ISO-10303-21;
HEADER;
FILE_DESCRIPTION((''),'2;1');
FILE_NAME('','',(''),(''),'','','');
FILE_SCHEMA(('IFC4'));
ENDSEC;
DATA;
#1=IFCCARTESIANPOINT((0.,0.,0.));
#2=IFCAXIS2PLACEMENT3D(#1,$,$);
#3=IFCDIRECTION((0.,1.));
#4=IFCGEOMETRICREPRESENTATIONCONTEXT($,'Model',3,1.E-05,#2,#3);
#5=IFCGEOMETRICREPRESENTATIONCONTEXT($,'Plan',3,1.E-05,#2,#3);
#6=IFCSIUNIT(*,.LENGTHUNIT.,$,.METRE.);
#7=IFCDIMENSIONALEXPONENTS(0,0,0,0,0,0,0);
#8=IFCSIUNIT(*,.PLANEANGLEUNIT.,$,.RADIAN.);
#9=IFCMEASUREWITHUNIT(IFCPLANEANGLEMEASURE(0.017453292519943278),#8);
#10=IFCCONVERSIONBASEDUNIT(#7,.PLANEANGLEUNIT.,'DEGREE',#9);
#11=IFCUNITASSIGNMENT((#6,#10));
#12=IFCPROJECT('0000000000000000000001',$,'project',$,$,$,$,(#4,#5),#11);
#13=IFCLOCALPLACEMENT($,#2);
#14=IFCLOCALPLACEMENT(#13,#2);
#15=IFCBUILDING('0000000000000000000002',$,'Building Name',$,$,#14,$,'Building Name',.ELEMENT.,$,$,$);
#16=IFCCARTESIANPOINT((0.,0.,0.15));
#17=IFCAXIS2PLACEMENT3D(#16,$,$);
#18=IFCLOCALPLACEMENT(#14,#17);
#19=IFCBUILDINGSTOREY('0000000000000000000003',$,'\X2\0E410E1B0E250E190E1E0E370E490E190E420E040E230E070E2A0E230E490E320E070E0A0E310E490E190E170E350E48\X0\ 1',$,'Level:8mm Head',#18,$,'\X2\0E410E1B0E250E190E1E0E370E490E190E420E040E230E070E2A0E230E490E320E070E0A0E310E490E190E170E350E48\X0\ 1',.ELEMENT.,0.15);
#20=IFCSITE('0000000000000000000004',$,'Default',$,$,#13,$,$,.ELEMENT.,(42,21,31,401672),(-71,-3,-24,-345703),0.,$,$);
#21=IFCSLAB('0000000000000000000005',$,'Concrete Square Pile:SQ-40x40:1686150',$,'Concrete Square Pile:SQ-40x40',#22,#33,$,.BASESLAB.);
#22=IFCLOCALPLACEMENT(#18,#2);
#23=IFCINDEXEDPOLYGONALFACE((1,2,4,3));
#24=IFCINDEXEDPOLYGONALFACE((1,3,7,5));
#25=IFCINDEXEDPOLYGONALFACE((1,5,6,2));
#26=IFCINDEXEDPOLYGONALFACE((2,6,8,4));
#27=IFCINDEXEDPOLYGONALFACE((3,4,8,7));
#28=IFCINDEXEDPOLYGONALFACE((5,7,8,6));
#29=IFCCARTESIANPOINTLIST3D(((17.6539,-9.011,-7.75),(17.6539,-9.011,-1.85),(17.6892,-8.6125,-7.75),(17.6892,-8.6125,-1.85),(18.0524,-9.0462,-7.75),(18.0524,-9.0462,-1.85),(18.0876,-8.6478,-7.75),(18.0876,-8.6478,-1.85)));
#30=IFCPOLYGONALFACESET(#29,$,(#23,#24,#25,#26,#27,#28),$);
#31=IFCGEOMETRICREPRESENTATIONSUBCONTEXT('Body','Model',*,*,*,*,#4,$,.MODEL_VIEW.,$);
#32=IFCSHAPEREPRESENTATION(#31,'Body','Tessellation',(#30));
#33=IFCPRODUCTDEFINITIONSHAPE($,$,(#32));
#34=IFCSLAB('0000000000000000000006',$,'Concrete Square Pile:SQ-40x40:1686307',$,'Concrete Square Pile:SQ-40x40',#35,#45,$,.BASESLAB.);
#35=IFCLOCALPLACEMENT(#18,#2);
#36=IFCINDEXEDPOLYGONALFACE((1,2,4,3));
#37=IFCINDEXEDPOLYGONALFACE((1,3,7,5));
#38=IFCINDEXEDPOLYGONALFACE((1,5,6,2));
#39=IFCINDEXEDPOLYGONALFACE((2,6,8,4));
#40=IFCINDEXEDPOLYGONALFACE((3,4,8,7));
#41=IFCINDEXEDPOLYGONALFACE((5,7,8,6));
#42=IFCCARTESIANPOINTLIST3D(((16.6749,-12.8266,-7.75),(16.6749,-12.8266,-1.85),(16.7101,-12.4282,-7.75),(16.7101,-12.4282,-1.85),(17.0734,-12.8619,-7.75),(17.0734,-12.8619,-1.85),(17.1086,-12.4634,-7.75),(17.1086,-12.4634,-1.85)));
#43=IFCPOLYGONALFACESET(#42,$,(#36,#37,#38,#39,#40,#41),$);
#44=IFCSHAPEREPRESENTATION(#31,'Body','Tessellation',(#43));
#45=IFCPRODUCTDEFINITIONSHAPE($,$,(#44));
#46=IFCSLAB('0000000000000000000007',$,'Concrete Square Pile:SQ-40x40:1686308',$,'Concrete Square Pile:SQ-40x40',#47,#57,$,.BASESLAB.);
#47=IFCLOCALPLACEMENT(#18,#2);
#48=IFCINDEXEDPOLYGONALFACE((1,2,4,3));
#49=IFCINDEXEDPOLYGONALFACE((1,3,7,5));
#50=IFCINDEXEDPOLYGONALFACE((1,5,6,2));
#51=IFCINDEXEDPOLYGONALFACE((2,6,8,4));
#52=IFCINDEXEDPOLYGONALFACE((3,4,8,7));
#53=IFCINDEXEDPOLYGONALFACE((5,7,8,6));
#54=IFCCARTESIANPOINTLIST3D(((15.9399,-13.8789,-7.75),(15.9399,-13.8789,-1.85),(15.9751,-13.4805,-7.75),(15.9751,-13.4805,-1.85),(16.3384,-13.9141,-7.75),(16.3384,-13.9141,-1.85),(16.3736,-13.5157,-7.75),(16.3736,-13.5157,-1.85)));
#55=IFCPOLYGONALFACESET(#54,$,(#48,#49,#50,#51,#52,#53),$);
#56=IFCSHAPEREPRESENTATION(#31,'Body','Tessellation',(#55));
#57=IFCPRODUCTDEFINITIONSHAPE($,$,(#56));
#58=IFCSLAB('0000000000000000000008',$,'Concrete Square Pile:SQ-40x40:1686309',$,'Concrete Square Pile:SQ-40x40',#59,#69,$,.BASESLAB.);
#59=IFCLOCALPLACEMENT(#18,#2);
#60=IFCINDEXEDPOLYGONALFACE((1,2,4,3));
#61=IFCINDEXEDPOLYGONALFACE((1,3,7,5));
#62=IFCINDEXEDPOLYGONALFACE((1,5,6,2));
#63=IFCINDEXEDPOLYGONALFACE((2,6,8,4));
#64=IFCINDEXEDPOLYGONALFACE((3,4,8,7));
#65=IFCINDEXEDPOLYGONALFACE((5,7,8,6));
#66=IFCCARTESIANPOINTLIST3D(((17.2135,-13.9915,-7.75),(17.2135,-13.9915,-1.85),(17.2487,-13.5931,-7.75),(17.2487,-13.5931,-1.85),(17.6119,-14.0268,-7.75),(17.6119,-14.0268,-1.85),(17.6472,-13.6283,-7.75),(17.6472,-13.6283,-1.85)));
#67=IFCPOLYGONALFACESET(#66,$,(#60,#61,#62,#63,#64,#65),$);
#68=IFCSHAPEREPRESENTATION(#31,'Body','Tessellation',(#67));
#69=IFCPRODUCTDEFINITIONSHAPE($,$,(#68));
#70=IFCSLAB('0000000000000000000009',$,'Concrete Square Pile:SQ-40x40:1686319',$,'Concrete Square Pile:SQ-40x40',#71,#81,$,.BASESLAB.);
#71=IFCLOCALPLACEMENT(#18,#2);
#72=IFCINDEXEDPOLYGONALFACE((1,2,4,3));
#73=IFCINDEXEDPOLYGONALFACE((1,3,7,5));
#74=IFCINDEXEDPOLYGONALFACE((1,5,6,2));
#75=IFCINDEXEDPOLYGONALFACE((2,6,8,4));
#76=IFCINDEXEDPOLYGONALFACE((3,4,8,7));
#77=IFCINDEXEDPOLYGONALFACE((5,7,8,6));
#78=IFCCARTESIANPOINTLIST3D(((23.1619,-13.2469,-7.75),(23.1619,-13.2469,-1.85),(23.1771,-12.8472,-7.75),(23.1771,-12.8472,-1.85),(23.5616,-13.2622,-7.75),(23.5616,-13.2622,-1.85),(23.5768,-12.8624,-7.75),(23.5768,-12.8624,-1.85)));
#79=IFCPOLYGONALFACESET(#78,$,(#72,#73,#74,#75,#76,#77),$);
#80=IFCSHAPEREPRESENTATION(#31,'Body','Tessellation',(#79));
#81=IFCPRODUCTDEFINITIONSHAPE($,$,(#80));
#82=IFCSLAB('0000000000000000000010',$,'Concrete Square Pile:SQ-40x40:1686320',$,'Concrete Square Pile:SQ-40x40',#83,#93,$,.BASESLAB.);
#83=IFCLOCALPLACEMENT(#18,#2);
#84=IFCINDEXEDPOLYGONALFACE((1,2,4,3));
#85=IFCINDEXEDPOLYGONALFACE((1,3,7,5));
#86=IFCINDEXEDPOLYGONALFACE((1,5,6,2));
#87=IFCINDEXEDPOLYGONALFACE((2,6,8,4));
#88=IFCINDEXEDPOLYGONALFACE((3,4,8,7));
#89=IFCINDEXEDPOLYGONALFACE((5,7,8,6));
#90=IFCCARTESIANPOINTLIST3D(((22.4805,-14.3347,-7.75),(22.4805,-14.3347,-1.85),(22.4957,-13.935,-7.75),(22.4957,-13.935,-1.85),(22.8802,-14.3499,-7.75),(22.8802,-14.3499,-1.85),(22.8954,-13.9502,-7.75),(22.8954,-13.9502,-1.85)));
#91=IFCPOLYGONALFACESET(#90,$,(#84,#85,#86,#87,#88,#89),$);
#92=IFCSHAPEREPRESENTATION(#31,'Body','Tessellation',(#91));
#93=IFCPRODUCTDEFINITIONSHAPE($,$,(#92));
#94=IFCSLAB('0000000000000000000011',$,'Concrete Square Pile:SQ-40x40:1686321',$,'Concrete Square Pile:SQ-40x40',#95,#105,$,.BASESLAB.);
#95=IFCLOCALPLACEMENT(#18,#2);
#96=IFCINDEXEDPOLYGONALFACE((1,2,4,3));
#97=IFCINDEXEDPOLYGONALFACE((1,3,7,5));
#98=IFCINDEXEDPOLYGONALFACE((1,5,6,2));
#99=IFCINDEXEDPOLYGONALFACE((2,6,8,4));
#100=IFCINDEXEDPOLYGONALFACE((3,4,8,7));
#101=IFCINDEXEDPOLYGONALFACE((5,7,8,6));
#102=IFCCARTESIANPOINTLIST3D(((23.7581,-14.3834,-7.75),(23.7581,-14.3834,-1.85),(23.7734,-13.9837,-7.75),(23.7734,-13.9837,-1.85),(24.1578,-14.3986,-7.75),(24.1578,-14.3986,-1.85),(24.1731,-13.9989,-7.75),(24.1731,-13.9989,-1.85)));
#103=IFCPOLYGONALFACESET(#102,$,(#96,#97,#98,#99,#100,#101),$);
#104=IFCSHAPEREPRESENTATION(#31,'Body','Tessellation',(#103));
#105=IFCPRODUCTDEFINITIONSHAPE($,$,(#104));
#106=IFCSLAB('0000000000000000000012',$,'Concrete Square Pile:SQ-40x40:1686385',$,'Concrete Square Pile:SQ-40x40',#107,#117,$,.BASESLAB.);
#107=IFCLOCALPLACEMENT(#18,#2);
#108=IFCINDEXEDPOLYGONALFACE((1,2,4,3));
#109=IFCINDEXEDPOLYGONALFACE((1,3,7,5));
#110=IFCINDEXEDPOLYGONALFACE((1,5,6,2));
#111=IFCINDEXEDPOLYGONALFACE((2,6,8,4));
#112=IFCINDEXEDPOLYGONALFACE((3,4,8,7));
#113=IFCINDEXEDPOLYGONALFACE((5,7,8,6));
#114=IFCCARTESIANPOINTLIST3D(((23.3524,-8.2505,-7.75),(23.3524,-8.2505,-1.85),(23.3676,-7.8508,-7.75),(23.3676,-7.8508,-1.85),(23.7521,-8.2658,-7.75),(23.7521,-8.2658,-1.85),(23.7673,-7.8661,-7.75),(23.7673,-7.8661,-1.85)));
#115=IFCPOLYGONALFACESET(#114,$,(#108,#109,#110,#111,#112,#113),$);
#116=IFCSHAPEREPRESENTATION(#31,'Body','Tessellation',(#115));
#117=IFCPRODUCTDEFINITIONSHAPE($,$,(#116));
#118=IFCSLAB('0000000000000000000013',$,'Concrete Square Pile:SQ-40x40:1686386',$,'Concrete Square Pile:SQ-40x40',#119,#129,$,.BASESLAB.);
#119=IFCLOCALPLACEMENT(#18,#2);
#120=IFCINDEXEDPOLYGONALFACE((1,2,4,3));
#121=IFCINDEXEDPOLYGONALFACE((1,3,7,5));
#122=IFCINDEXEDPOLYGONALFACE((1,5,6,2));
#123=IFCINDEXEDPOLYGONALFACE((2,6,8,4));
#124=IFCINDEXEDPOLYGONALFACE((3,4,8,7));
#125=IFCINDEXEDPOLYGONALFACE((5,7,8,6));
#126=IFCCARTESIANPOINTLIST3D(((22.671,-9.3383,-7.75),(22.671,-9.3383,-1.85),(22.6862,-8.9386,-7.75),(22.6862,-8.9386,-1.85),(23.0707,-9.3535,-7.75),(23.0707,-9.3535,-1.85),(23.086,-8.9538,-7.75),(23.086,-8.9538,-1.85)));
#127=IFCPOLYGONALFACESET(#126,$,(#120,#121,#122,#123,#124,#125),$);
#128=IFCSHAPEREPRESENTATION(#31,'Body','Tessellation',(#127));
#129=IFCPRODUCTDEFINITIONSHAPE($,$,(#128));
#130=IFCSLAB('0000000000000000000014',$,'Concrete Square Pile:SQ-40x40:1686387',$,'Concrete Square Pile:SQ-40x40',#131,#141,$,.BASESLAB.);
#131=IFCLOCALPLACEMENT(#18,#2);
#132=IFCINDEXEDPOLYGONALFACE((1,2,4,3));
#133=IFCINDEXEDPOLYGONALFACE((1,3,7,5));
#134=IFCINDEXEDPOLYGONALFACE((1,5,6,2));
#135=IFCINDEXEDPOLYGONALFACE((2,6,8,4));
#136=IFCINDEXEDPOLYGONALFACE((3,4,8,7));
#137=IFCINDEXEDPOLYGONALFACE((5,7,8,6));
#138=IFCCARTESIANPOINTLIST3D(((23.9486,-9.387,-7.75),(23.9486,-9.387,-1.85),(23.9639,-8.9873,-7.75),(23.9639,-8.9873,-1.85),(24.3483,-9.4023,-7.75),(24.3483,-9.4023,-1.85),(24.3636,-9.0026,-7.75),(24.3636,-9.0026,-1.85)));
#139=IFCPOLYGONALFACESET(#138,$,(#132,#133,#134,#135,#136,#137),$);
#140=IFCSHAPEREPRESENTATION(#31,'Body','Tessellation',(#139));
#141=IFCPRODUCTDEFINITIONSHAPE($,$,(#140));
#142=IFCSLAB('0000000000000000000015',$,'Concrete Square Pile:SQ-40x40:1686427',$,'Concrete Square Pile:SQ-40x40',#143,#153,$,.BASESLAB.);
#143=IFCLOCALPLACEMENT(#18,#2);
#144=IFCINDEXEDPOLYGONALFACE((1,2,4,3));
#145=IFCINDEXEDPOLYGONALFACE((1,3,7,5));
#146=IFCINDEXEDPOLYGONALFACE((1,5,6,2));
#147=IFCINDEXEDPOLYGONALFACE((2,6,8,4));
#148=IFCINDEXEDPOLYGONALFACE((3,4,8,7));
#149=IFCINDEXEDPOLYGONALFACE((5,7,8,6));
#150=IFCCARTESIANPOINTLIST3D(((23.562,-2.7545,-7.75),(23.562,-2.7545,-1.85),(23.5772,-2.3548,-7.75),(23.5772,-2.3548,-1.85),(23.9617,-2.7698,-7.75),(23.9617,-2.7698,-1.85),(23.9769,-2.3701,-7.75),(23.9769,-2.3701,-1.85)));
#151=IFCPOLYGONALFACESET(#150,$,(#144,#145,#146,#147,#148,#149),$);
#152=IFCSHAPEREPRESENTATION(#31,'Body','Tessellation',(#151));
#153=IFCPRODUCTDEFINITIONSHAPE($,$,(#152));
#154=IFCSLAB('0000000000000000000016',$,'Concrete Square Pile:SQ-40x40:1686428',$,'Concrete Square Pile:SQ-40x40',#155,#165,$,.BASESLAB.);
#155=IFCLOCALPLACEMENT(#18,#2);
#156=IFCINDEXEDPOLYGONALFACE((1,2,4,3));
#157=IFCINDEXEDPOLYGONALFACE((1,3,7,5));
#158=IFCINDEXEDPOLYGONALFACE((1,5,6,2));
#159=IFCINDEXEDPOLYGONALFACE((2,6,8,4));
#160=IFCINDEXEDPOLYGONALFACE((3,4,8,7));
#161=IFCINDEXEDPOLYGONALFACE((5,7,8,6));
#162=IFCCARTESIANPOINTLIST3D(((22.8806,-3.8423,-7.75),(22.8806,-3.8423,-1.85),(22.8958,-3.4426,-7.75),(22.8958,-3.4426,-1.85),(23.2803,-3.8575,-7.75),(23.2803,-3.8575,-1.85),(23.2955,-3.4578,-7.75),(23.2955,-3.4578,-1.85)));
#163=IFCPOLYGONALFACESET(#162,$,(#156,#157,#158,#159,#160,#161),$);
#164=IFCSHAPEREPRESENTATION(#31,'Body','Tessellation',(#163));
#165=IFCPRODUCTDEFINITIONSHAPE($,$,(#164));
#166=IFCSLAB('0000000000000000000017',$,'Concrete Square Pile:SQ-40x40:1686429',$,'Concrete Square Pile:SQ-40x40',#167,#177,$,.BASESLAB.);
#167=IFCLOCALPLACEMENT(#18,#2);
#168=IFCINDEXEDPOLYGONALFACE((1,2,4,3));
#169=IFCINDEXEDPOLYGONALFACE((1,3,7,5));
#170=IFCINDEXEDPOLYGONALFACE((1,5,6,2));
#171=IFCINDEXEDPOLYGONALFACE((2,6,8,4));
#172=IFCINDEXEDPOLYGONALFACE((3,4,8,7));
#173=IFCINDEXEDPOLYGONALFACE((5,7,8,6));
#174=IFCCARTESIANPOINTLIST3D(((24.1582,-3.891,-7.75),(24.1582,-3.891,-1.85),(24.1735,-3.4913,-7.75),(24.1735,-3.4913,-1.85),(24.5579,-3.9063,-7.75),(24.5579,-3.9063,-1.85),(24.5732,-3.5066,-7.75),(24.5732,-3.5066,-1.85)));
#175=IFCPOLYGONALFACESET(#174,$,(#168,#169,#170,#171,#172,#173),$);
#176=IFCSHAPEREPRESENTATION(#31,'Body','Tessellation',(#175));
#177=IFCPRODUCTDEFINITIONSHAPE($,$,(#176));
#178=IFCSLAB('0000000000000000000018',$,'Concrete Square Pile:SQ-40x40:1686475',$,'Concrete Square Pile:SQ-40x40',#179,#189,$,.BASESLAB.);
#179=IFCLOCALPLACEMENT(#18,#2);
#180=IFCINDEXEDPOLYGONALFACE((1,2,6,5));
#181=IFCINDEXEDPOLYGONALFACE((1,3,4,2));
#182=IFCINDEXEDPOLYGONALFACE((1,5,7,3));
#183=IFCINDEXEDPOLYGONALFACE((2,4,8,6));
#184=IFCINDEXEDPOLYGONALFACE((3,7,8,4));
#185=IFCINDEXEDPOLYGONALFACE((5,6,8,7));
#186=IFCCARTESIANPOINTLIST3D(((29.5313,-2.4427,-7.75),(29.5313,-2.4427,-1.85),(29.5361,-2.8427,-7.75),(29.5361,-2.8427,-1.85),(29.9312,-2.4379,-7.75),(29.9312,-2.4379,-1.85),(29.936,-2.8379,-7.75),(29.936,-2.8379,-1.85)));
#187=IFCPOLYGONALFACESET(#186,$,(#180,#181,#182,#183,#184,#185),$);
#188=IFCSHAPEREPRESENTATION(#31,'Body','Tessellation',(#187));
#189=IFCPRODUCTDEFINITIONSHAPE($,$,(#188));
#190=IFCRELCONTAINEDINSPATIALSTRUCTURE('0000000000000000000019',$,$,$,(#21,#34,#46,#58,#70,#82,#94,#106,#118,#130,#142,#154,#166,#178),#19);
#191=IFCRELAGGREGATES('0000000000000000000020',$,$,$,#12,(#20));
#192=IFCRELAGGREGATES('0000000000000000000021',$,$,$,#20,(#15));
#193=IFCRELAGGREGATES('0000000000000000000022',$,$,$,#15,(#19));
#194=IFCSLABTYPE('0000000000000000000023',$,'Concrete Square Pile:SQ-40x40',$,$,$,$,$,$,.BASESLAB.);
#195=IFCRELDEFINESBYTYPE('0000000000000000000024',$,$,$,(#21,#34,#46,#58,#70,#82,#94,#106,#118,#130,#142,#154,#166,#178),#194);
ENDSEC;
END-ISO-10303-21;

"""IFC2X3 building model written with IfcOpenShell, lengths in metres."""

from ifc_helpers import new_model, entity, si_unit, converted_unit, direction, frame, frame_2d, origin, origin_2d_with_axis, place, context, subcontext, project, spatial, rectangle, extrude, type_object, element, save


model = new_model("IFC2X3")

# Units and contexts
model_context = context("Model", 3, precision=1e-05, world=origin(), true_north=direction((0.0, 1.0)))
plan_context = context("Plan", 3, precision=1e-05, world=origin(), true_north=direction((0.0, 1.0)))
body_context = subcontext(model_context, "Body", "Model", "MODEL_VIEW")
ifc_project = project(units=[si_unit("LENGTHUNIT", "METRE"), converted_unit("PLANEANGLEUNIT", "DEGREE", entity("IfcPlaneAngleMeasure", 0.017453292519943278), si_unit("PLANEANGLEUNIT", "RADIAN"), dimensions=[0, 0, 0, 0, 0, 0, 0])], contexts=[model_context, plan_context])

# Site, building, storey
site_placement = place(None, origin())
site = spatial("IfcSite", under=ifc_project, at=site_placement, Name="Default", CompositionType="ELEMENT", RefLatitude=(42, 21, 31, 401672), RefLongitude=(-71, -3, -24, -345703), RefElevation=0.0)
building_placement = place(site_placement, origin())
building = spatial("IfcBuilding", under=site, at=building_placement, Name="Building Name", LongName="Building Name", CompositionType="ELEMENT")
storey_placement = place(building_placement, frame((0.0, 0.0, 0.15)))
storey = spatial("IfcBuildingStorey", under=building, at=storey_placement, Name="แปลนพื้นโครงสร้างชั้นที่ 1", ObjectType="Level:8mm Head", LongName="แปลนพื้นโครงสร้างชั้นที่ 1", CompositionType="ELEMENT", Elevation=0.15)

# Slabs
slab_type_1 = type_object("IfcSlabType", Name="Concrete Square Pile:SQ-40x40", PredefinedType="BASESLAB")
slab_1_placement = place(storey_placement, origin())
element("IfcSlab", 1, at=slab_1_placement, inside=storey, type_object=slab_type_1, Name="Concrete Square Pile:SQ-40x40:1686150", ObjectType="Concrete Square Pile:SQ-40x40", PredefinedType="BASESLAB", context=body_context, shape_type="SweptSolid", body=[
    extrude(rectangle(XDim=0.4, YDim=0.4, at=origin_2d_with_axis()), frame((17.8708, -8.8294, -7.75), z_axis=(0.0, 0.0, 1.0), x_axis=(-0.996113, 0.088086, 0.0)), (0.0, 0.0, 1.0), 5.9),
])
slab_2_placement = place(storey_placement, origin())
element("IfcSlab", 2, at=slab_2_placement, inside=storey, type_object=slab_type_1, Name="Concrete Square Pile:SQ-40x40:1686307", ObjectType="Concrete Square Pile:SQ-40x40", PredefinedType="BASESLAB", context=body_context, shape_type="SweptSolid", body=[
    extrude(rectangle(XDim=0.4, YDim=0.4, at=origin_2d_with_axis()), frame((16.8917, -12.645, -7.75), z_axis=(0.0, 0.0, 1.0), x_axis=(-0.996113, 0.088086, 0.0)), (0.0, 0.0, 1.0), 5.9),
])
slab_3_placement = place(storey_placement, origin())
element("IfcSlab", 3, at=slab_3_placement, inside=storey, type_object=slab_type_1, Name="Concrete Square Pile:SQ-40x40:1686308", ObjectType="Concrete Square Pile:SQ-40x40", PredefinedType="BASESLAB", context=body_context, shape_type="SweptSolid", body=[
    extrude(rectangle(XDim=0.4, YDim=0.4, at=origin_2d_with_axis()), frame((16.1568, -13.6973, -7.75), z_axis=(0.0, 0.0, 1.0), x_axis=(-0.996113, 0.088086, 0.0)), (0.0, 0.0, 1.0), 5.9),
])
slab_4_placement = place(storey_placement, origin())
element("IfcSlab", 4, at=slab_4_placement, inside=storey, type_object=slab_type_1, Name="Concrete Square Pile:SQ-40x40:1686309", ObjectType="Concrete Square Pile:SQ-40x40", PredefinedType="BASESLAB", context=body_context, shape_type="SweptSolid", body=[
    extrude(rectangle(XDim=0.4, YDim=0.4, at=frame_2d((0.0, 0.0), x_axis=(1.0, 0.0))), frame((17.4303, -13.8099, -7.75), z_axis=(0.0, 0.0, 1.0), x_axis=(-0.996113, 0.088086, 0.0)), (0.0, 0.0, 1.0), 5.9),
])
slab_5_placement = place(storey_placement, origin())
element("IfcSlab", 5, at=slab_5_placement, inside=storey, type_object=slab_type_1, Name="Concrete Square Pile:SQ-40x40:1686319", ObjectType="Concrete Square Pile:SQ-40x40", PredefinedType="BASESLAB", context=body_context, shape_type="SweptSolid", body=[
    extrude(rectangle(XDim=0.4, YDim=0.4, at=frame_2d((0.0, 0.0), x_axis=(1.0, 0.0))), frame((23.3693, -13.0547, -7.75), z_axis=(0.0, 0.0, 1.0), x_axis=(-0.999274, 0.038106, 0.0)), (0.0, 0.0, 1.0), 5.9),
])
slab_6_placement = place(storey_placement, origin())
element("IfcSlab", 6, at=slab_6_placement, inside=storey, type_object=slab_type_1, Name="Concrete Square Pile:SQ-40x40:1686320", ObjectType="Concrete Square Pile:SQ-40x40", PredefinedType="BASESLAB", context=body_context, shape_type="SweptSolid", body=[
    extrude(rectangle(XDim=0.4, YDim=0.4, at=frame_2d((0.0, 0.0), x_axis=(1.0, 0.0))), frame((22.688, -14.1424, -7.75), z_axis=(0.0, 0.0, 1.0), x_axis=(-0.999274, 0.038106, 0.0)), (0.0, 0.0, 1.0), 5.9),
])
slab_7_placement = place(storey_placement, origin())
element("IfcSlab", 7, at=slab_7_placement, inside=storey, type_object=slab_type_1, Name="Concrete Square Pile:SQ-40x40:1686321", ObjectType="Concrete Square Pile:SQ-40x40", PredefinedType="BASESLAB", context=body_context, shape_type="SweptSolid", body=[
    extrude(rectangle(XDim=0.4, YDim=0.4, at=frame_2d((0.0, 0.0), x_axis=(1.0, 0.0))), frame((23.9656, -14.1912, -7.75), z_axis=(0.0, 0.0, 1.0), x_axis=(-0.999274, 0.038106, 0.0)), (0.0, 0.0, 1.0), 5.9),
])
slab_8_placement = place(storey_placement, origin())
element("IfcSlab", 8, at=slab_8_placement, inside=storey, type_object=slab_type_1, Name="Concrete Square Pile:SQ-40x40:1686385", ObjectType="Concrete Square Pile:SQ-40x40", PredefinedType="BASESLAB", context=body_context, shape_type="SweptSolid", body=[
    extrude(rectangle(XDim=0.4, YDim=0.4, at=frame_2d((0.0, 0.0), x_axis=(1.0, 0.0))), frame((23.5599, -8.0583, -7.75), z_axis=(0.0, 0.0, 1.0), x_axis=(-0.999274, 0.038106, 0.0)), (0.0, 0.0, 1.0), 5.9),
])
slab_9_placement = place(storey_placement, origin())
element("IfcSlab", 9, at=slab_9_placement, inside=storey, type_object=slab_type_1, Name="Concrete Square Pile:SQ-40x40:1686386", ObjectType="Concrete Square Pile:SQ-40x40", PredefinedType="BASESLAB", context=body_context, shape_type="SweptSolid", body=[
    extrude(rectangle(XDim=0.4, YDim=0.4, at=origin_2d_with_axis()), frame((22.8785, -9.1461, -7.75), z_axis=(0.0, 0.0, 1.0), x_axis=(-0.999274, 0.038106, 0.0)), (0.0, 0.0, 1.0), 5.9),
])
slab_10_placement = place(storey_placement, origin())
element("IfcSlab", 10, at=slab_10_placement, inside=storey, type_object=slab_type_1, Name="Concrete Square Pile:SQ-40x40:1686387", ObjectType="Concrete Square Pile:SQ-40x40", PredefinedType="BASESLAB", context=body_context, shape_type="SweptSolid", body=[
    extrude(rectangle(XDim=0.4, YDim=0.4, at=origin_2d_with_axis()), frame((24.1561, -9.1948, -7.75), z_axis=(0.0, 0.0, 1.0), x_axis=(-0.999274, 0.038106, 0.0)), (0.0, 0.0, 1.0), 5.9),
])
slab_11_placement = place(storey_placement, origin())
element("IfcSlab", 11, at=slab_11_placement, inside=storey, type_object=slab_type_1, Name="Concrete Square Pile:SQ-40x40:1686427", ObjectType="Concrete Square Pile:SQ-40x40", PredefinedType="BASESLAB", context=body_context, shape_type="SweptSolid", body=[
    extrude(rectangle(XDim=0.4, YDim=0.4, at=frame_2d((0.0, 0.0), x_axis=(1.0, 0.0))), frame((23.7695, -2.5623, -7.75), z_axis=(0.0, 0.0, 1.0), x_axis=(-0.999274, 0.038106, 0.0)), (0.0, 0.0, 1.0), 5.9),
])
slab_12_placement = place(storey_placement, origin())
element("IfcSlab", 12, at=slab_12_placement, inside=storey, type_object=slab_type_1, Name="Concrete Square Pile:SQ-40x40:1686428", ObjectType="Concrete Square Pile:SQ-40x40", PredefinedType="BASESLAB", context=body_context, shape_type="SweptSolid", body=[
    extrude(rectangle(XDim=0.4, YDim=0.4, at=frame_2d((0.0, 0.0), x_axis=(1.0, 0.0))), frame((23.0881, -3.6501, -7.75), z_axis=(0.0, 0.0, 1.0), x_axis=(-0.999274, 0.038106, 0.0)), (0.0, 0.0, 1.0), 5.9),
])
slab_13_placement = place(storey_placement, origin())
element("IfcSlab", 13, at=slab_13_placement, inside=storey, type_object=slab_type_1, Name="Concrete Square Pile:SQ-40x40:1686429", ObjectType="Concrete Square Pile:SQ-40x40", PredefinedType="BASESLAB", context=body_context, shape_type="SweptSolid", body=[
    extrude(rectangle(XDim=0.4, YDim=0.4, at=frame_2d((0.0, 0.0), x_axis=(1.0, 0.0))), frame((24.3657, -3.6988, -7.75), z_axis=(0.0, 0.0, 1.0), x_axis=(-0.999274, 0.038106, 0.0)), (0.0, 0.0, 1.0), 5.9),
])
slab_14_placement = place(storey_placement, origin())
element("IfcSlab", 14, at=slab_14_placement, inside=storey, type_object=slab_type_1, Name="Concrete Square Pile:SQ-40x40:1686475", ObjectType="Concrete Square Pile:SQ-40x40", PredefinedType="BASESLAB", context=body_context, shape_type="SweptSolid", body=[
    extrude(rectangle(XDim=0.4, YDim=0.4, at=frame_2d((0.0, 0.0), x_axis=(1.0, 0.0))), frame((29.7337, -2.6403, -7.75), z_axis=(0.0, 0.0, 1.0), x_axis=(-0.999928, -0.011969, 0.0)), (0.0, 0.0, 1.0), 5.9),
])

save(model, "model.ifc")
